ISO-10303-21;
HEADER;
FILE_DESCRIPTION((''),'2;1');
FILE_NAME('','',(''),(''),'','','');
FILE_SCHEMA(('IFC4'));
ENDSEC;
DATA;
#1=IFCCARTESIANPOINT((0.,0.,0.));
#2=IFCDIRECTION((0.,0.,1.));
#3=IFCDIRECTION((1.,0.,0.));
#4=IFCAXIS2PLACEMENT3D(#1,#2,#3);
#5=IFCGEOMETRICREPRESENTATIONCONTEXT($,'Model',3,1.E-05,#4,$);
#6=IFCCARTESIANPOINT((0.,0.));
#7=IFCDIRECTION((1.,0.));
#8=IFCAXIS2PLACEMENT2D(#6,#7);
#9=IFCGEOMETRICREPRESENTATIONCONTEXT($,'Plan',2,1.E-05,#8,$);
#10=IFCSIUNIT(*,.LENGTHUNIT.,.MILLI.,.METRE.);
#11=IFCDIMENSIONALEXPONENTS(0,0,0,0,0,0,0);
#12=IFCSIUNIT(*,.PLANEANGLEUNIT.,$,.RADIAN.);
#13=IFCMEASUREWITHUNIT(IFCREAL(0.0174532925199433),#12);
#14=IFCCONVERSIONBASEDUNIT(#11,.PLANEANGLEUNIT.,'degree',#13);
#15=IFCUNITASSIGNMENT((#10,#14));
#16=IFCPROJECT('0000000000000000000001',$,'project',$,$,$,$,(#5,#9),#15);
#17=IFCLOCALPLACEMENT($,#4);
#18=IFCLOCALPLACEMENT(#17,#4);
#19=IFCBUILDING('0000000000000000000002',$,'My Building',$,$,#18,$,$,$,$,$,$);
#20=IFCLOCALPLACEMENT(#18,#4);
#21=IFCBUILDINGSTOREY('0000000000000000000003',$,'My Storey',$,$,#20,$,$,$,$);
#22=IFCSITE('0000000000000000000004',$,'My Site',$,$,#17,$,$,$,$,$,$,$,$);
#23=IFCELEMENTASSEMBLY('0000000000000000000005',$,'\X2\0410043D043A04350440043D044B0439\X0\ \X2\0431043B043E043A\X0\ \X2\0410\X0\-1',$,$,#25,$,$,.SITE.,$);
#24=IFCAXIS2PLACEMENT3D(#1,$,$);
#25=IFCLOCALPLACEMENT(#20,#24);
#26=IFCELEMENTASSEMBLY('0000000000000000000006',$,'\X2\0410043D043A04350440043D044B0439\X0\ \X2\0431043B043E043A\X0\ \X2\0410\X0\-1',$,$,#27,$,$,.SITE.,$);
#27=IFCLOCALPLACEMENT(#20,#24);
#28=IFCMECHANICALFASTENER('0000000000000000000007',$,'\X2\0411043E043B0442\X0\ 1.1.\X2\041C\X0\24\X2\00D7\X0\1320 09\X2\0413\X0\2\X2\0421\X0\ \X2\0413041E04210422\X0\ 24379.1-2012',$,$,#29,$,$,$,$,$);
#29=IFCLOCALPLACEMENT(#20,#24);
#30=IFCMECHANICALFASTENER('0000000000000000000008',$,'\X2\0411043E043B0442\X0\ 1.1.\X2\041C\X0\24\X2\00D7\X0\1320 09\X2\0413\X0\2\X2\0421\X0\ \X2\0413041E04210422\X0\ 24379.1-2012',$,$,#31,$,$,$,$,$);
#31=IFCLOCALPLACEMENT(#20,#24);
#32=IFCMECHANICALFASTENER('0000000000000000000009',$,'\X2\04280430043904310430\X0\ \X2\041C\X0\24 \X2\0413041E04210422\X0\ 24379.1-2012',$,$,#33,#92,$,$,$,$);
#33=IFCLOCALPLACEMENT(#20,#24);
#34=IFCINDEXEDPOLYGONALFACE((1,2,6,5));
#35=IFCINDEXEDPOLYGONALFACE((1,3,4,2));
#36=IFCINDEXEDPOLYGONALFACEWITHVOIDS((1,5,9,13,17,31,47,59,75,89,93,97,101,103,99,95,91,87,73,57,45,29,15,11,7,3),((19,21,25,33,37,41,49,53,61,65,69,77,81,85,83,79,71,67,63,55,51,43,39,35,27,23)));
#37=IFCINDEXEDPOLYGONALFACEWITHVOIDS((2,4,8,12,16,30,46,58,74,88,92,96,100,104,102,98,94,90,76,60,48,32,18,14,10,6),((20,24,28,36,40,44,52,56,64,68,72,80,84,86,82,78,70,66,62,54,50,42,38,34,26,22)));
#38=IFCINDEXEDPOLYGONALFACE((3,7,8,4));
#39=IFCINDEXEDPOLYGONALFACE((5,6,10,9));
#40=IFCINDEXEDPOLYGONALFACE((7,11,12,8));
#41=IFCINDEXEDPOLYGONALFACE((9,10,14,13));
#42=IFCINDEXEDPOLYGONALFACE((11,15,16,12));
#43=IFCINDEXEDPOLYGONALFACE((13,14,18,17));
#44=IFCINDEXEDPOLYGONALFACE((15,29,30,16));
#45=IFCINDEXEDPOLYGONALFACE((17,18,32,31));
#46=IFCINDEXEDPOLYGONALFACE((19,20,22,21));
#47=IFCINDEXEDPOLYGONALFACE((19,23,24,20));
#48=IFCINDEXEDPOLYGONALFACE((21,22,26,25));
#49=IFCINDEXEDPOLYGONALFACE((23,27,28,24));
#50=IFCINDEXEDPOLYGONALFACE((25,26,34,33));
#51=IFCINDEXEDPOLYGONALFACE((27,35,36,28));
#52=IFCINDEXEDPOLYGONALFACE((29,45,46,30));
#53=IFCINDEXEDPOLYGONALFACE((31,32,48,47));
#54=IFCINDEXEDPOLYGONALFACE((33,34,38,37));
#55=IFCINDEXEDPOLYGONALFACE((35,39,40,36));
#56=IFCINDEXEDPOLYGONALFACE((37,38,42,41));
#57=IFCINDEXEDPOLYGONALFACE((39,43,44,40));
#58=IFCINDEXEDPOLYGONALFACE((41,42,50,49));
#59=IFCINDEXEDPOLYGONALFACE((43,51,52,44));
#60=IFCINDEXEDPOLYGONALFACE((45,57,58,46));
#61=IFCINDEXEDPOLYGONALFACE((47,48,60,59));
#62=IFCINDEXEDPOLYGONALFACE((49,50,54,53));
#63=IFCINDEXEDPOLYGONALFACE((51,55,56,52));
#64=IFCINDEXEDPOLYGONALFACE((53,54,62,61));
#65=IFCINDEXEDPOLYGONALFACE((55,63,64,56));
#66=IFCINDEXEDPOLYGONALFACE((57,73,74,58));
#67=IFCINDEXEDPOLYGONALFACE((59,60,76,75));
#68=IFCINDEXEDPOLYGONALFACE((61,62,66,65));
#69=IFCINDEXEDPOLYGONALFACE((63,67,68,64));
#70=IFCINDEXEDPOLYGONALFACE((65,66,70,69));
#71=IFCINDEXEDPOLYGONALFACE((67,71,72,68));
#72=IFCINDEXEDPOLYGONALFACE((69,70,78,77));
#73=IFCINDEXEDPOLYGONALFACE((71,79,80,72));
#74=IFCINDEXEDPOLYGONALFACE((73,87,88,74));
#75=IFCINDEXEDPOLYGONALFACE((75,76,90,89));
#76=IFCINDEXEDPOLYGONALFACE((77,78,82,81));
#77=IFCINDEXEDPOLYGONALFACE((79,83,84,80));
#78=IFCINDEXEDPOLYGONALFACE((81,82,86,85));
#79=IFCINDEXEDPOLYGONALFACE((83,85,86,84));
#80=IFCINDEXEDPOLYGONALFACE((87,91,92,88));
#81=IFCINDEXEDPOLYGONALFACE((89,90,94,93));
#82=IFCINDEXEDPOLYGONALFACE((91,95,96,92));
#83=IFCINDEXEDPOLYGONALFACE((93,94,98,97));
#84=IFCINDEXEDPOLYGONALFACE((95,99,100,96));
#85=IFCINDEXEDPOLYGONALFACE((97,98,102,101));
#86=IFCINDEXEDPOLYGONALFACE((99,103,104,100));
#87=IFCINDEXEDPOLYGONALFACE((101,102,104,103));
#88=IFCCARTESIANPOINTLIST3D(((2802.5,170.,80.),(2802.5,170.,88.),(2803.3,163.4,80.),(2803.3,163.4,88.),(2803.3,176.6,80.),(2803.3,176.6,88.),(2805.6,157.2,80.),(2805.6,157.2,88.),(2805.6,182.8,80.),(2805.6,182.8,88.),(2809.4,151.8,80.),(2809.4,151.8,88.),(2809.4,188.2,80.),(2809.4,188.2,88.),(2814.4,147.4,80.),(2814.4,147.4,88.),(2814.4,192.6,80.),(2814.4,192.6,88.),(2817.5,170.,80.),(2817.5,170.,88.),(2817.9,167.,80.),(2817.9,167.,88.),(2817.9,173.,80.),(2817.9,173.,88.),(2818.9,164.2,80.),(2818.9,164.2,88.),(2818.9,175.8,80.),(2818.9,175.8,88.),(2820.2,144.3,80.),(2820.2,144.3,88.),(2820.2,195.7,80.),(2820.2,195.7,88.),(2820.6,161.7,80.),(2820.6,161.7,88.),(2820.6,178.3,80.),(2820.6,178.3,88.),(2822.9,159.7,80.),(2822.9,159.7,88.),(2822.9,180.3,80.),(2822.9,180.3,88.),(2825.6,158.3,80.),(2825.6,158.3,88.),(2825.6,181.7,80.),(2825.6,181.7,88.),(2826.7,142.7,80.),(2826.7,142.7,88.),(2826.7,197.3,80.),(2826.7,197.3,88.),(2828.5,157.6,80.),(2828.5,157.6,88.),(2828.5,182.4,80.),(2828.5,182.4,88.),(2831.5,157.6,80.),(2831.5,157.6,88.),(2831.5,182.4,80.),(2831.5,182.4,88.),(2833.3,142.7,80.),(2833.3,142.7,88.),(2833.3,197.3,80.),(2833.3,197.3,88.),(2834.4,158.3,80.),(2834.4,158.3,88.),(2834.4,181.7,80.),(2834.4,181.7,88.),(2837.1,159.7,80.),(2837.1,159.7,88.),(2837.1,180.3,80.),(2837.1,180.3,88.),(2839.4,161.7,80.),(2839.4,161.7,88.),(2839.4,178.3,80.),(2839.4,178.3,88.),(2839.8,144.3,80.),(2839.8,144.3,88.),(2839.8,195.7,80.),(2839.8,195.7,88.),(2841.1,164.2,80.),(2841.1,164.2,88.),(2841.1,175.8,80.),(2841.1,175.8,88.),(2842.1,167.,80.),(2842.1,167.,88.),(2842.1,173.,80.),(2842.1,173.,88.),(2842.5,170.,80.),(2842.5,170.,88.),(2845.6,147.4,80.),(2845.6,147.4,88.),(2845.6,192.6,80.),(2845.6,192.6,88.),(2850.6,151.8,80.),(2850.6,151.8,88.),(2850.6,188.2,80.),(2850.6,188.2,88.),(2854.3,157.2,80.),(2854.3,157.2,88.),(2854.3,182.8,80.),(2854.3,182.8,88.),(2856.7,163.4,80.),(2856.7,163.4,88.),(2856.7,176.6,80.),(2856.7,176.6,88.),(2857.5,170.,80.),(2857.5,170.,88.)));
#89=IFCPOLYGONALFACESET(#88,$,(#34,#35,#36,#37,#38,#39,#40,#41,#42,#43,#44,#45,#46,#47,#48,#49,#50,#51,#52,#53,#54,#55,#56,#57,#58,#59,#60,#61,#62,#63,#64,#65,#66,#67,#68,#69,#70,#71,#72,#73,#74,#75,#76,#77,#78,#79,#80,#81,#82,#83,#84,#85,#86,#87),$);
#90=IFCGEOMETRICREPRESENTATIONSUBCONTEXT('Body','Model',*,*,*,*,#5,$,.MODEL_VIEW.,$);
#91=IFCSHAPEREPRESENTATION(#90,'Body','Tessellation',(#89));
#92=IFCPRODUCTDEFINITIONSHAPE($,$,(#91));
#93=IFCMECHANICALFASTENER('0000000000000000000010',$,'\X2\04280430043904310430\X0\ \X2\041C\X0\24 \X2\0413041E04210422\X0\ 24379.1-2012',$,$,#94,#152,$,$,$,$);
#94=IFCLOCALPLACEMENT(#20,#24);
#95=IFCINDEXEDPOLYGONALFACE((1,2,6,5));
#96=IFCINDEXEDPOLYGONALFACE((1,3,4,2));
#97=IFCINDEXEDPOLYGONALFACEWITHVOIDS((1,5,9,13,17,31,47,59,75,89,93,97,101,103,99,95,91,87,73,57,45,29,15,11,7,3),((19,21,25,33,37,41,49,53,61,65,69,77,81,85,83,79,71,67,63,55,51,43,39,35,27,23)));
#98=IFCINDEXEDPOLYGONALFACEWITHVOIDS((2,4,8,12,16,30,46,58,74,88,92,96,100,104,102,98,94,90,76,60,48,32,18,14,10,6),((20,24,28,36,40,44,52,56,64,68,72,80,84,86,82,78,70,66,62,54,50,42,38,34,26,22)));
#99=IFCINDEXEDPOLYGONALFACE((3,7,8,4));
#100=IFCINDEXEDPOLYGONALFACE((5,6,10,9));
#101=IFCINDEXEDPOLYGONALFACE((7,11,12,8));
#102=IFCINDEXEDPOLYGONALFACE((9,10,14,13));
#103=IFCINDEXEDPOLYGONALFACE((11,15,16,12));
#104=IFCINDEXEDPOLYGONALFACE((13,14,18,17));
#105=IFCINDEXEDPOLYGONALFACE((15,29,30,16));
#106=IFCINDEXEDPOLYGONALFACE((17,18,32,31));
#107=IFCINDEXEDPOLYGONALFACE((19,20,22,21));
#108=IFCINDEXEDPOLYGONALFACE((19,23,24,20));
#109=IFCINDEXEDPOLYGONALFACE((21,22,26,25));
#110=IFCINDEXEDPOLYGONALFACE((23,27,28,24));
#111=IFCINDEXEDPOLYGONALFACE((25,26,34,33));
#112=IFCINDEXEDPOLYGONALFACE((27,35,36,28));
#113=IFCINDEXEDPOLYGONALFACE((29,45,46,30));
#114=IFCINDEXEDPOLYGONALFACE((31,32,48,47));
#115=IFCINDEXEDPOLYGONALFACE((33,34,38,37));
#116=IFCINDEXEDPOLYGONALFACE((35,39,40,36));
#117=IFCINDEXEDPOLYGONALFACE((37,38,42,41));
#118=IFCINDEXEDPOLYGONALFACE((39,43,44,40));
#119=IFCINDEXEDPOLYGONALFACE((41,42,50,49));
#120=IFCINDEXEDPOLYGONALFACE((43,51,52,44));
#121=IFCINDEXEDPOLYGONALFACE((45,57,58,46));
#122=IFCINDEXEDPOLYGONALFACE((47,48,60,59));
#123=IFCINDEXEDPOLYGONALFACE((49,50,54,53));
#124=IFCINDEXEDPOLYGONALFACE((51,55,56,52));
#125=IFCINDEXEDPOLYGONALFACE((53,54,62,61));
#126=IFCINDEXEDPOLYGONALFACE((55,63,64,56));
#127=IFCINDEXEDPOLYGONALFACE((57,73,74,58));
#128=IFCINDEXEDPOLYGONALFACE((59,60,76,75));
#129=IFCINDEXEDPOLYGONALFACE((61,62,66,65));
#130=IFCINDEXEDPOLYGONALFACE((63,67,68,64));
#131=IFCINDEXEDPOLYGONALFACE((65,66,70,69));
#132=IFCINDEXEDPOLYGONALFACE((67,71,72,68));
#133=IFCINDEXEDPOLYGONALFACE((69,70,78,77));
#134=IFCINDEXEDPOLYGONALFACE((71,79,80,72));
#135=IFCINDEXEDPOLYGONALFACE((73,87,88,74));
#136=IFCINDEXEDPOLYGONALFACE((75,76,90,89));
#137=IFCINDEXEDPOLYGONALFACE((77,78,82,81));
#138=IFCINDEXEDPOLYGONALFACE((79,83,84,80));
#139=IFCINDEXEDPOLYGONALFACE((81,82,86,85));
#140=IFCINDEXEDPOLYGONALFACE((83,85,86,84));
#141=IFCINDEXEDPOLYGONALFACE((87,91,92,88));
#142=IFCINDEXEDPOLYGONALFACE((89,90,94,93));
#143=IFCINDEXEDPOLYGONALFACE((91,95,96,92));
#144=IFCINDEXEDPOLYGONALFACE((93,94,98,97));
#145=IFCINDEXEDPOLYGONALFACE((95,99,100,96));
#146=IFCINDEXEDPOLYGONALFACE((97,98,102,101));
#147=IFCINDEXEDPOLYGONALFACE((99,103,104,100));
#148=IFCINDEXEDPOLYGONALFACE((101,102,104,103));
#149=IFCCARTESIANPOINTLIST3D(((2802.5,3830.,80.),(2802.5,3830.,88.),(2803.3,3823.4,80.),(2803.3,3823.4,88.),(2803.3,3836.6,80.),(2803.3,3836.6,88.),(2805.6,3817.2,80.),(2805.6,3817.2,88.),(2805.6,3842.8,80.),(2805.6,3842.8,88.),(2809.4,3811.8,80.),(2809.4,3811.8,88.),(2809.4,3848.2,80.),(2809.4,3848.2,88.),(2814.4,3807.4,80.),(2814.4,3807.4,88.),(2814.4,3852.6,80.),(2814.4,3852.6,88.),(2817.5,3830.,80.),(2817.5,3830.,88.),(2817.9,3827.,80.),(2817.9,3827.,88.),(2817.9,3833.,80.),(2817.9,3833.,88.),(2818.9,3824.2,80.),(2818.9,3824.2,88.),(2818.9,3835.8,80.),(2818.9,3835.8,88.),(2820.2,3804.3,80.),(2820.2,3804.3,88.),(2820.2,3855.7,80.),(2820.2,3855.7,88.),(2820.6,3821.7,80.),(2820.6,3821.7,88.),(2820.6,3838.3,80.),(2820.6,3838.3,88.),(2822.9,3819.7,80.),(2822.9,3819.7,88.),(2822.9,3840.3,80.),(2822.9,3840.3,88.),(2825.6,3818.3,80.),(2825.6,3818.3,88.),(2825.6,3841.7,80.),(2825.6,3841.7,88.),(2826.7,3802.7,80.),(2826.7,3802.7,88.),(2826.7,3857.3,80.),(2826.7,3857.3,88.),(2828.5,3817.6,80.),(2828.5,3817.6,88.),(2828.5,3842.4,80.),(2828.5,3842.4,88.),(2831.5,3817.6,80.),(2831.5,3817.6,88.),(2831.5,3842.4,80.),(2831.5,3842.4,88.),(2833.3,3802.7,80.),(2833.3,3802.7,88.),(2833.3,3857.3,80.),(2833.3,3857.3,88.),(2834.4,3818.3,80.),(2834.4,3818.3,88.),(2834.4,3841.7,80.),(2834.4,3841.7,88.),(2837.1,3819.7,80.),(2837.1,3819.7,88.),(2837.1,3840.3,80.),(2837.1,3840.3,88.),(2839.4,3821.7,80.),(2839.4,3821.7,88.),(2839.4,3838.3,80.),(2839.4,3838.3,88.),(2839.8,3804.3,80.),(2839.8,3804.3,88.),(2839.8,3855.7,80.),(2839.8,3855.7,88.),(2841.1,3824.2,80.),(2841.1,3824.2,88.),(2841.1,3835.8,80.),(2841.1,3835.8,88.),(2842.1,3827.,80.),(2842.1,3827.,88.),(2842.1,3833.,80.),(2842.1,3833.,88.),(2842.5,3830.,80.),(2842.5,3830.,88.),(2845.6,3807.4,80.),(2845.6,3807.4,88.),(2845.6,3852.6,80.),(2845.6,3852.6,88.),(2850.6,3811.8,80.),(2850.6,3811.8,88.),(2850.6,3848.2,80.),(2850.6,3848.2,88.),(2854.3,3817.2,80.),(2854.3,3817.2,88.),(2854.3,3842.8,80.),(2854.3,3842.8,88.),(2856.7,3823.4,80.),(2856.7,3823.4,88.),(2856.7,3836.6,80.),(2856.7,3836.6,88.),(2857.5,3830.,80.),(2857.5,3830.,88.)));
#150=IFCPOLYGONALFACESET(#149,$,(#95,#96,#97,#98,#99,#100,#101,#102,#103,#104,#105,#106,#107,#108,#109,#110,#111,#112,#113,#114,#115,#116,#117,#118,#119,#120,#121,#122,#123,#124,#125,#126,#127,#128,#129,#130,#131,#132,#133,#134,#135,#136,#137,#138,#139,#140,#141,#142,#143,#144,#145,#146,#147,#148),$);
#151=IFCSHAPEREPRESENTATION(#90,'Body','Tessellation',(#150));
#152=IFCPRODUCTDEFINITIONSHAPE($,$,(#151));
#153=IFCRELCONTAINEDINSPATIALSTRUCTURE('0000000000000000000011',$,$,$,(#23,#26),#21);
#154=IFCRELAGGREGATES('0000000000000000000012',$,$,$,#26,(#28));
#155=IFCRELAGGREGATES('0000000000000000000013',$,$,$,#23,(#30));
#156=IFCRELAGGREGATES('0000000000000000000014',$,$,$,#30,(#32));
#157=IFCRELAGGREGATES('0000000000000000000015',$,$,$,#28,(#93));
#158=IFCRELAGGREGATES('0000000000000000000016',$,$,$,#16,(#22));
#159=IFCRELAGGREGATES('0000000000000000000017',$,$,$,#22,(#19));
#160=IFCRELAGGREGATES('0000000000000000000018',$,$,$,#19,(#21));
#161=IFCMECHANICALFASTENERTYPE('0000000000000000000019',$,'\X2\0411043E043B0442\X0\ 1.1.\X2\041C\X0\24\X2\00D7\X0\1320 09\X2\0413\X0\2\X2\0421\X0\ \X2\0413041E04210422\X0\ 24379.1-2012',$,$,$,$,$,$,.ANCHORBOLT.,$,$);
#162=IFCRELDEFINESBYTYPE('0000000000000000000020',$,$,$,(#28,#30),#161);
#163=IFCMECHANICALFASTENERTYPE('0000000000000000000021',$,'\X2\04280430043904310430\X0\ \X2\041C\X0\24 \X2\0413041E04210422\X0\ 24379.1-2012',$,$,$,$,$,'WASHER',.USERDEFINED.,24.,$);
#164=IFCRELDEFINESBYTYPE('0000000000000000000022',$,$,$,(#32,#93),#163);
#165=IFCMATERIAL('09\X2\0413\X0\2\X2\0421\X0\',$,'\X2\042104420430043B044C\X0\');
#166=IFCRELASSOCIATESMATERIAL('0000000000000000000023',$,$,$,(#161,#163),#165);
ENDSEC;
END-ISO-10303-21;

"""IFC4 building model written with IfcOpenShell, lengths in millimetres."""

from ifc_helpers import new_model, entity, si_unit, converted_unit, frame, origin_with_axes, origin_2d_with_axis, place, context, subcontext, project, spatial, polyline, outline, extrude, source, transform, mapped, material, type_object, type_shapes, element, aggregate, save


model = new_model("IFC4")

# Units and contexts
model_context = context("Model", 3, precision=1e-05, world=origin_with_axes())
plan_context = context("Plan", 2, precision=1e-05, world=origin_2d_with_axis())
body_context = subcontext(model_context, "Body", "Model", "MODEL_VIEW")
ifc_project = project(units=[si_unit("LENGTHUNIT", "METRE", prefix="MILLI"), converted_unit("PLANEANGLEUNIT", "degree", entity("IfcReal", 0.0174532925199433), si_unit("PLANEANGLEUNIT", "RADIAN"), dimensions=[0, 0, 0, 0, 0, 0, 0])], contexts=[model_context, plan_context])

# Site, building, storey
site_placement = place(None, origin_with_axes())
site = spatial("IfcSite", under=ifc_project, at=site_placement, Name="My Site")
building_placement = place(site_placement, origin_with_axes())
building = spatial("IfcBuilding", under=site, at=building_placement, Name="My Building")
storey_placement = place(building_placement, origin_with_axes())
storey = spatial("IfcBuildingStorey", under=building, at=storey_placement, Name="My Storey")

# Element assembly
assembly_1_placement = place(storey_placement, frame((3000.0, 0.0, 0.0), z_axis=(0.0, 0.0, 1.0), x_axis=(1.0, 0.0, 0.0)))
assembly_1 = element("IfcElementAssembly", 1, at=assembly_1_placement, inside=storey, Name="Анкерный блок А-1", AssemblyPlace="SITE")

# Element assembly, mechanical fastener
ifc_material_1 = material(Name="09Г2С", Category="Сталь")
mechanical_fastener_type_1 = type_object("IfcMechanicalFastenerType", Name="Болт 1.1.М24×1320 09Г2С ГОСТ 24379.1-2012", PredefinedType="ANCHORBOLT", material=ifc_material_1)
assembly_2_placement = place(storey_placement, frame((3000.0, 4000.0, 0.0), z_axis=(0.0, 0.0, 1.0), x_axis=(1.0, 0.0, 0.0)))
assembly_2 = element("IfcElementAssembly", 2, at=assembly_2_placement, inside=storey, Name="Анкерный блок А-1", AssemblyPlace="SITE")
mechanical_fastener_1_placement = place(assembly_2_placement, frame((-170.0, -170.0, 0.0), z_axis=(0.0, 0.0, 1.0), x_axis=(1.0, 0.0, 0.0)))
mechanical_fastener_1 = element("IfcMechanicalFastener", 3, at=mechanical_fastener_1_placement, type_object=mechanical_fastener_type_1, Name="Болт 1.1.М24×1320 09Г2С ГОСТ 24379.1-2012")
aggregate(assembly_2, [mechanical_fastener_1])

# Mechanical fasteners
mechanical_fastener_type_2 = type_object("IfcMechanicalFastenerType", Name="Шайба М24 ГОСТ 24379.1-2012", ElementType="WASHER", NominalDiameter=24.0, PredefinedType="USERDEFINED", material=ifc_material_1)
shared_shape_1 = source(origin_with_axes(), body_context, "Body", "SweptSolid", [
    extrude(outline(polyline([(27.5, 0.0), (26.7, 6.6), (24.4, 12.8), (20.6, 18.2), (15.6, 22.6), (9.8, 25.7), (3.3, 27.3), (-3.3, 27.3), (-9.8, 25.7), (-15.6, 22.6), (-20.6, 18.2), (-24.4, 12.8), (-26.7, 6.6), (-27.5, 0.0), (-26.7, -6.6), (-24.4, -12.8), (-20.6, -18.2), (-15.6, -22.6), (-9.8, -25.7), (-3.3, -27.3), (3.3, -27.3), (9.8, -25.7), (15.6, -22.6), (20.6, -18.2), (24.4, -12.8), (26.7, -6.6), (27.5, 0.0)]), holes=[polyline([(-4.4, -11.7), (-7.1, -10.3), (-9.4, -8.3), (-11.1, -5.8), (-12.1, -3.0), (-12.5, 0.0), (-12.1, 3.0), (-11.1, 5.8), (-9.4, 8.3), (-7.1, 10.3), (-4.4, 11.7), (-1.5, 12.4), (1.5, 12.4), (4.4, 11.7), (7.1, 10.3), (9.4, 8.3), (11.1, 5.8), (12.1, 3.0), (12.5, 0.0), (12.1, -3.0), (11.1, -5.8), (9.4, -8.3), (7.1, -10.3), (4.4, -11.7), (1.5, -12.4), (-1.5, -12.4), (-4.4, -11.7)])]), frame((0.0, 0.0, 0.0), z_axis=(0.0, 0.0, 1.0), x_axis=(0.120537, -0.992709, 0.0)), (0.0, 0.0, 1.0), 8.0),
])
type_shapes(mechanical_fastener_type_2, [shared_shape_1])
mechanical_fastener_2_placement = place(assembly_1_placement, frame((-170.0, 170.0, 0.0), z_axis=(0.0, 0.0, 1.0), x_axis=(-1.0, 0.0, 0.0)))
mechanical_fastener_2 = element("IfcMechanicalFastener", 4, at=mechanical_fastener_2_placement, type_object=mechanical_fastener_type_1, Name="Болт 1.1.М24×1320 09Г2С ГОСТ 24379.1-2012")
aggregate(assembly_1, [mechanical_fastener_2])
mechanical_fastener_3_placement = place(mechanical_fastener_2_placement, frame((0.0, 0.0, 80.0), z_axis=(0.0, 0.0, 1.0), x_axis=(1.0, 0.0, 0.0)))
mechanical_fastener_3 = element("IfcMechanicalFastener", 5, at=mechanical_fastener_3_placement, type_object=mechanical_fastener_type_2, Name="Шайба М24 ГОСТ 24379.1-2012", context=body_context, shape_type="MappedRepresentation", body=[
    mapped(shared_shape_1, transform((0.0, 0.0, 0.0), x_axis=(1.0, 0.0, 0.0), y_axis=(0.0, 1.0, 0.0), z_axis=(0.0, 0.0, 1.0), scale=1.0)),
])
aggregate(mechanical_fastener_2, [mechanical_fastener_3])
mechanical_fastener_4_placement = place(mechanical_fastener_1_placement, frame((0.0, 0.0, 80.0), z_axis=(0.0, 0.0, 1.0), x_axis=(1.0, 0.0, 0.0)))
mechanical_fastener_4 = element("IfcMechanicalFastener", 6, at=mechanical_fastener_4_placement, type_object=mechanical_fastener_type_2, Name="Шайба М24 ГОСТ 24379.1-2012", context=body_context, shape_type="MappedRepresentation", body=[
    mapped(shared_shape_1, transform((0.0, 0.0, 0.0), x_axis=(1.0, 0.0, 0.0), y_axis=(0.0, 1.0, 0.0), z_axis=(0.0, 0.0, 1.0), scale=1.0)),
])
aggregate(mechanical_fastener_1, [mechanical_fastener_4])

save(model, "model.ifc")
